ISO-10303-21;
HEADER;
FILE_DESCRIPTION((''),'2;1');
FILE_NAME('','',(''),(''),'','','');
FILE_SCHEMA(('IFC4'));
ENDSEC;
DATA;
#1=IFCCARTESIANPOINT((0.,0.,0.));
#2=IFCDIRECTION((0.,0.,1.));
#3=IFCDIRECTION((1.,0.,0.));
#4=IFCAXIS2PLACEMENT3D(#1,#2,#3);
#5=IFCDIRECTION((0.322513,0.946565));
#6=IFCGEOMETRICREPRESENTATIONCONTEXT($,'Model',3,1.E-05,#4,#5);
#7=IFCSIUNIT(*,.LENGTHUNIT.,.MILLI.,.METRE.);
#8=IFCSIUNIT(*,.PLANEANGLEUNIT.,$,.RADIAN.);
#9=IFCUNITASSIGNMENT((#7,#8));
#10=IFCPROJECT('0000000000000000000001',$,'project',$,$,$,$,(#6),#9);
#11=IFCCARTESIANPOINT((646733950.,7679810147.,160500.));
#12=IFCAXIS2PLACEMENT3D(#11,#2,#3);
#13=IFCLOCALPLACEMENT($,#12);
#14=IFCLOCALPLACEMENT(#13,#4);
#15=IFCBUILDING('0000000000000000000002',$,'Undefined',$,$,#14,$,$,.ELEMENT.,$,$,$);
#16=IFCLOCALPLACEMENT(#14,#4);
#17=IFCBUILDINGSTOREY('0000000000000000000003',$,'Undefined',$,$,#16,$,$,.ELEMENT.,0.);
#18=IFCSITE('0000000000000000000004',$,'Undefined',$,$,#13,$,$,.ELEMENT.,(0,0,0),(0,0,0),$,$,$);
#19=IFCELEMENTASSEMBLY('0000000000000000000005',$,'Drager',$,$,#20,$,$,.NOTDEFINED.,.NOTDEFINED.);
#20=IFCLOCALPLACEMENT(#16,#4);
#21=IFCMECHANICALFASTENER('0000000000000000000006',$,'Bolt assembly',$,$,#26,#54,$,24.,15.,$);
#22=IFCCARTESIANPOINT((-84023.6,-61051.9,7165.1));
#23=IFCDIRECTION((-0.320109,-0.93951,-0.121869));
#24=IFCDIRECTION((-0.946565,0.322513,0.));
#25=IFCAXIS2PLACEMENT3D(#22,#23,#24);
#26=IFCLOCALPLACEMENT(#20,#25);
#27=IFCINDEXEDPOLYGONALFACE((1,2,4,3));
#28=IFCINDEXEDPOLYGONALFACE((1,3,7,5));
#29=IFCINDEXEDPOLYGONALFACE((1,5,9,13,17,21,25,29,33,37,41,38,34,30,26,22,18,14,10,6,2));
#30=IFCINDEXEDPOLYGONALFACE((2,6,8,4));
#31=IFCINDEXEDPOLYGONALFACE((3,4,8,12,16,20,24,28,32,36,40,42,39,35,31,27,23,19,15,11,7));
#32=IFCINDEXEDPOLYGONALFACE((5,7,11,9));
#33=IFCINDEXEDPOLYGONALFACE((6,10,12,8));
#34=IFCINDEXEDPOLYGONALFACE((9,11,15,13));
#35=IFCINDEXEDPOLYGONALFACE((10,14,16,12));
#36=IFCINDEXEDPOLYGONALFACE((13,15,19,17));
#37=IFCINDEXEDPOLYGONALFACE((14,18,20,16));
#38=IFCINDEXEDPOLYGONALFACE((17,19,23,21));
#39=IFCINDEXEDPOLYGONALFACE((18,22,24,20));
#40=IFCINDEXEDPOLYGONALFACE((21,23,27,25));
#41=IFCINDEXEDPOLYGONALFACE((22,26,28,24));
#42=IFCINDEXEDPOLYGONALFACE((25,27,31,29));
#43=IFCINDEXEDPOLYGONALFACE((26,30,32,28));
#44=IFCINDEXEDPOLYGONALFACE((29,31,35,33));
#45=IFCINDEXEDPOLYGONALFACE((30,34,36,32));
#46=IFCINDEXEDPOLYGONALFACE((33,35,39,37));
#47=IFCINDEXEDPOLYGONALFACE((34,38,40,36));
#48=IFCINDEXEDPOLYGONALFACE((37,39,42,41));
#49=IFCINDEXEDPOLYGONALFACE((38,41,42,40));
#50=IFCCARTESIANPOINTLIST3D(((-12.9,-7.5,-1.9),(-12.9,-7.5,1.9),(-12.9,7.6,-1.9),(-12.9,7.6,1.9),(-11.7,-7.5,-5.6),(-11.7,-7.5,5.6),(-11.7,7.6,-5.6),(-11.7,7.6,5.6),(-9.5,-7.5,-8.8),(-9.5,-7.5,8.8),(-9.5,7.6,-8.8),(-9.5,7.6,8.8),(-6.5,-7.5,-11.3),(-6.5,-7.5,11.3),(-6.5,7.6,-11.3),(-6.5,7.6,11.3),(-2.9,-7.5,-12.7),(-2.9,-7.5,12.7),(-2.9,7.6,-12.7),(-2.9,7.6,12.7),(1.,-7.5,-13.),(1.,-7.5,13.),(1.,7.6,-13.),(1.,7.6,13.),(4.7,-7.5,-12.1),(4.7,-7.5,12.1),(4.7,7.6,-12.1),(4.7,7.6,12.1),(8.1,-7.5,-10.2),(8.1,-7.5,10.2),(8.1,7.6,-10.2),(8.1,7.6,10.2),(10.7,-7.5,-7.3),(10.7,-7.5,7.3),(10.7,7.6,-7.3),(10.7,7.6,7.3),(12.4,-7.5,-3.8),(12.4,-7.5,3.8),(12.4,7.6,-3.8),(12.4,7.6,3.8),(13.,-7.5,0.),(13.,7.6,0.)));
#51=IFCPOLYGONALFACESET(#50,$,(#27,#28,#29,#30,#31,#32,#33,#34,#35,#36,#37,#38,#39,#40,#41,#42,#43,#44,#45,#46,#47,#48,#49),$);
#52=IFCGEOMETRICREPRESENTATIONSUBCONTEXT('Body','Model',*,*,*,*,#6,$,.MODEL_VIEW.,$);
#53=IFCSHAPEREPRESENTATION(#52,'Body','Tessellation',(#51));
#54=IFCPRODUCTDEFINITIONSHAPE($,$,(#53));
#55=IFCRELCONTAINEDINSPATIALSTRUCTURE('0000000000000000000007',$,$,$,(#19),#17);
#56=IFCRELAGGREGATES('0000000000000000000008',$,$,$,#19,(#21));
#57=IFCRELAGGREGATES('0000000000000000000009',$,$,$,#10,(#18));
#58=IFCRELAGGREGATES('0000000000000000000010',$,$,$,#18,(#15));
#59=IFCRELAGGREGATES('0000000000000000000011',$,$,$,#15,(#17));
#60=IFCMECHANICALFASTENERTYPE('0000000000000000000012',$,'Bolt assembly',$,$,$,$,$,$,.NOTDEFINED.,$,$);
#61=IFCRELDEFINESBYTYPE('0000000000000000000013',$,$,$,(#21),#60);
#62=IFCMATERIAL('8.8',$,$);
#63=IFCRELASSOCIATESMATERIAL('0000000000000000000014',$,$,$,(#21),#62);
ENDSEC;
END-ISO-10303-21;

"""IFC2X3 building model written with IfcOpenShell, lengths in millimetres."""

from ifc_helpers import new_model, si_unit, direction, frame, origin_with_axes, origin_2d_with_axis, place, context, subcontext, project, spatial, circle, extrude, source, transform, mapped, material, type_object, element, aggregate, save


model = new_model("IFC2X3")

# Units and contexts
model_context = context("Model", 3, precision=1e-05, world=origin_with_axes(), true_north=direction((0.322513, 0.946565)))
body_context = subcontext(model_context, "Body", "Model", "MODEL_VIEW")
ifc_project = project(units=[si_unit("LENGTHUNIT", "METRE", prefix="MILLI"), si_unit("PLANEANGLEUNIT", "RADIAN")], contexts=[model_context])

# Site, building, storey
site_placement = place(None, frame((646733950.0, 7679810147.0, 160500.0), z_axis=(0.0, 0.0, 1.0), x_axis=(1.0, 0.0, 0.0)))
site = spatial("IfcSite", under=ifc_project, at=site_placement, Name="Undefined", CompositionType="ELEMENT", RefLatitude=(0, 0, 0), RefLongitude=(0, 0, 0))
building_placement = place(site_placement, origin_with_axes())
building = spatial("IfcBuilding", under=site, at=building_placement, Name="Undefined", CompositionType="ELEMENT")
storey_placement = place(building_placement, origin_with_axes())
storey = spatial("IfcBuildingStorey", under=building, at=storey_placement, Name="Undefined", CompositionType="ELEMENT", Elevation=0.0)

# Shared definitions
ifc_material_1 = material(Name="8.8")
mechanical_fastener_type = type_object("IfcMechanicalFastenerType", Name="Bolt assembly")
shared_shape_1 = source(origin_with_axes(), body_context, "Body", "SweptSolid", [
    extrude(circle(Radius=13.0, at=origin_2d_with_axis()), frame((0.0, -7.5, 0.0), z_axis=(0.0, 1.0, 0.0), x_axis=(1.0, 0.0, 0.0)), (0.0, 0.0, 1.0), 15.1),
])

# Element assembly, mechanical fastener
assembly_1_placement = place(storey_placement, origin_with_axes())
assembly_1 = element("IfcElementAssembly", 1, at=assembly_1_placement, inside=storey, Name="Drager", AssemblyPlace="NOTDEFINED", PredefinedType="NOTDEFINED")
mechanical_fastener_1_placement = place(assembly_1_placement, frame((-84023.6, -61051.9, 7165.1), z_axis=(-0.320109, -0.93951, -0.121869), x_axis=(-0.946565, 0.322513, 0.0)))
mechanical_fastener_1 = element("IfcMechanicalFastener", 2, at=mechanical_fastener_1_placement, type_object=mechanical_fastener_type, material=ifc_material_1, Name="Bolt assembly", NominalDiameter=24.0, NominalLength=15.0, context=body_context, shape_type="MappedRepresentation", body=[
    mapped(shared_shape_1, transform((0.0, 0.0, 0.0))),
])
aggregate(assembly_1, [mechanical_fastener_1])

save(model, "model.ifc")
